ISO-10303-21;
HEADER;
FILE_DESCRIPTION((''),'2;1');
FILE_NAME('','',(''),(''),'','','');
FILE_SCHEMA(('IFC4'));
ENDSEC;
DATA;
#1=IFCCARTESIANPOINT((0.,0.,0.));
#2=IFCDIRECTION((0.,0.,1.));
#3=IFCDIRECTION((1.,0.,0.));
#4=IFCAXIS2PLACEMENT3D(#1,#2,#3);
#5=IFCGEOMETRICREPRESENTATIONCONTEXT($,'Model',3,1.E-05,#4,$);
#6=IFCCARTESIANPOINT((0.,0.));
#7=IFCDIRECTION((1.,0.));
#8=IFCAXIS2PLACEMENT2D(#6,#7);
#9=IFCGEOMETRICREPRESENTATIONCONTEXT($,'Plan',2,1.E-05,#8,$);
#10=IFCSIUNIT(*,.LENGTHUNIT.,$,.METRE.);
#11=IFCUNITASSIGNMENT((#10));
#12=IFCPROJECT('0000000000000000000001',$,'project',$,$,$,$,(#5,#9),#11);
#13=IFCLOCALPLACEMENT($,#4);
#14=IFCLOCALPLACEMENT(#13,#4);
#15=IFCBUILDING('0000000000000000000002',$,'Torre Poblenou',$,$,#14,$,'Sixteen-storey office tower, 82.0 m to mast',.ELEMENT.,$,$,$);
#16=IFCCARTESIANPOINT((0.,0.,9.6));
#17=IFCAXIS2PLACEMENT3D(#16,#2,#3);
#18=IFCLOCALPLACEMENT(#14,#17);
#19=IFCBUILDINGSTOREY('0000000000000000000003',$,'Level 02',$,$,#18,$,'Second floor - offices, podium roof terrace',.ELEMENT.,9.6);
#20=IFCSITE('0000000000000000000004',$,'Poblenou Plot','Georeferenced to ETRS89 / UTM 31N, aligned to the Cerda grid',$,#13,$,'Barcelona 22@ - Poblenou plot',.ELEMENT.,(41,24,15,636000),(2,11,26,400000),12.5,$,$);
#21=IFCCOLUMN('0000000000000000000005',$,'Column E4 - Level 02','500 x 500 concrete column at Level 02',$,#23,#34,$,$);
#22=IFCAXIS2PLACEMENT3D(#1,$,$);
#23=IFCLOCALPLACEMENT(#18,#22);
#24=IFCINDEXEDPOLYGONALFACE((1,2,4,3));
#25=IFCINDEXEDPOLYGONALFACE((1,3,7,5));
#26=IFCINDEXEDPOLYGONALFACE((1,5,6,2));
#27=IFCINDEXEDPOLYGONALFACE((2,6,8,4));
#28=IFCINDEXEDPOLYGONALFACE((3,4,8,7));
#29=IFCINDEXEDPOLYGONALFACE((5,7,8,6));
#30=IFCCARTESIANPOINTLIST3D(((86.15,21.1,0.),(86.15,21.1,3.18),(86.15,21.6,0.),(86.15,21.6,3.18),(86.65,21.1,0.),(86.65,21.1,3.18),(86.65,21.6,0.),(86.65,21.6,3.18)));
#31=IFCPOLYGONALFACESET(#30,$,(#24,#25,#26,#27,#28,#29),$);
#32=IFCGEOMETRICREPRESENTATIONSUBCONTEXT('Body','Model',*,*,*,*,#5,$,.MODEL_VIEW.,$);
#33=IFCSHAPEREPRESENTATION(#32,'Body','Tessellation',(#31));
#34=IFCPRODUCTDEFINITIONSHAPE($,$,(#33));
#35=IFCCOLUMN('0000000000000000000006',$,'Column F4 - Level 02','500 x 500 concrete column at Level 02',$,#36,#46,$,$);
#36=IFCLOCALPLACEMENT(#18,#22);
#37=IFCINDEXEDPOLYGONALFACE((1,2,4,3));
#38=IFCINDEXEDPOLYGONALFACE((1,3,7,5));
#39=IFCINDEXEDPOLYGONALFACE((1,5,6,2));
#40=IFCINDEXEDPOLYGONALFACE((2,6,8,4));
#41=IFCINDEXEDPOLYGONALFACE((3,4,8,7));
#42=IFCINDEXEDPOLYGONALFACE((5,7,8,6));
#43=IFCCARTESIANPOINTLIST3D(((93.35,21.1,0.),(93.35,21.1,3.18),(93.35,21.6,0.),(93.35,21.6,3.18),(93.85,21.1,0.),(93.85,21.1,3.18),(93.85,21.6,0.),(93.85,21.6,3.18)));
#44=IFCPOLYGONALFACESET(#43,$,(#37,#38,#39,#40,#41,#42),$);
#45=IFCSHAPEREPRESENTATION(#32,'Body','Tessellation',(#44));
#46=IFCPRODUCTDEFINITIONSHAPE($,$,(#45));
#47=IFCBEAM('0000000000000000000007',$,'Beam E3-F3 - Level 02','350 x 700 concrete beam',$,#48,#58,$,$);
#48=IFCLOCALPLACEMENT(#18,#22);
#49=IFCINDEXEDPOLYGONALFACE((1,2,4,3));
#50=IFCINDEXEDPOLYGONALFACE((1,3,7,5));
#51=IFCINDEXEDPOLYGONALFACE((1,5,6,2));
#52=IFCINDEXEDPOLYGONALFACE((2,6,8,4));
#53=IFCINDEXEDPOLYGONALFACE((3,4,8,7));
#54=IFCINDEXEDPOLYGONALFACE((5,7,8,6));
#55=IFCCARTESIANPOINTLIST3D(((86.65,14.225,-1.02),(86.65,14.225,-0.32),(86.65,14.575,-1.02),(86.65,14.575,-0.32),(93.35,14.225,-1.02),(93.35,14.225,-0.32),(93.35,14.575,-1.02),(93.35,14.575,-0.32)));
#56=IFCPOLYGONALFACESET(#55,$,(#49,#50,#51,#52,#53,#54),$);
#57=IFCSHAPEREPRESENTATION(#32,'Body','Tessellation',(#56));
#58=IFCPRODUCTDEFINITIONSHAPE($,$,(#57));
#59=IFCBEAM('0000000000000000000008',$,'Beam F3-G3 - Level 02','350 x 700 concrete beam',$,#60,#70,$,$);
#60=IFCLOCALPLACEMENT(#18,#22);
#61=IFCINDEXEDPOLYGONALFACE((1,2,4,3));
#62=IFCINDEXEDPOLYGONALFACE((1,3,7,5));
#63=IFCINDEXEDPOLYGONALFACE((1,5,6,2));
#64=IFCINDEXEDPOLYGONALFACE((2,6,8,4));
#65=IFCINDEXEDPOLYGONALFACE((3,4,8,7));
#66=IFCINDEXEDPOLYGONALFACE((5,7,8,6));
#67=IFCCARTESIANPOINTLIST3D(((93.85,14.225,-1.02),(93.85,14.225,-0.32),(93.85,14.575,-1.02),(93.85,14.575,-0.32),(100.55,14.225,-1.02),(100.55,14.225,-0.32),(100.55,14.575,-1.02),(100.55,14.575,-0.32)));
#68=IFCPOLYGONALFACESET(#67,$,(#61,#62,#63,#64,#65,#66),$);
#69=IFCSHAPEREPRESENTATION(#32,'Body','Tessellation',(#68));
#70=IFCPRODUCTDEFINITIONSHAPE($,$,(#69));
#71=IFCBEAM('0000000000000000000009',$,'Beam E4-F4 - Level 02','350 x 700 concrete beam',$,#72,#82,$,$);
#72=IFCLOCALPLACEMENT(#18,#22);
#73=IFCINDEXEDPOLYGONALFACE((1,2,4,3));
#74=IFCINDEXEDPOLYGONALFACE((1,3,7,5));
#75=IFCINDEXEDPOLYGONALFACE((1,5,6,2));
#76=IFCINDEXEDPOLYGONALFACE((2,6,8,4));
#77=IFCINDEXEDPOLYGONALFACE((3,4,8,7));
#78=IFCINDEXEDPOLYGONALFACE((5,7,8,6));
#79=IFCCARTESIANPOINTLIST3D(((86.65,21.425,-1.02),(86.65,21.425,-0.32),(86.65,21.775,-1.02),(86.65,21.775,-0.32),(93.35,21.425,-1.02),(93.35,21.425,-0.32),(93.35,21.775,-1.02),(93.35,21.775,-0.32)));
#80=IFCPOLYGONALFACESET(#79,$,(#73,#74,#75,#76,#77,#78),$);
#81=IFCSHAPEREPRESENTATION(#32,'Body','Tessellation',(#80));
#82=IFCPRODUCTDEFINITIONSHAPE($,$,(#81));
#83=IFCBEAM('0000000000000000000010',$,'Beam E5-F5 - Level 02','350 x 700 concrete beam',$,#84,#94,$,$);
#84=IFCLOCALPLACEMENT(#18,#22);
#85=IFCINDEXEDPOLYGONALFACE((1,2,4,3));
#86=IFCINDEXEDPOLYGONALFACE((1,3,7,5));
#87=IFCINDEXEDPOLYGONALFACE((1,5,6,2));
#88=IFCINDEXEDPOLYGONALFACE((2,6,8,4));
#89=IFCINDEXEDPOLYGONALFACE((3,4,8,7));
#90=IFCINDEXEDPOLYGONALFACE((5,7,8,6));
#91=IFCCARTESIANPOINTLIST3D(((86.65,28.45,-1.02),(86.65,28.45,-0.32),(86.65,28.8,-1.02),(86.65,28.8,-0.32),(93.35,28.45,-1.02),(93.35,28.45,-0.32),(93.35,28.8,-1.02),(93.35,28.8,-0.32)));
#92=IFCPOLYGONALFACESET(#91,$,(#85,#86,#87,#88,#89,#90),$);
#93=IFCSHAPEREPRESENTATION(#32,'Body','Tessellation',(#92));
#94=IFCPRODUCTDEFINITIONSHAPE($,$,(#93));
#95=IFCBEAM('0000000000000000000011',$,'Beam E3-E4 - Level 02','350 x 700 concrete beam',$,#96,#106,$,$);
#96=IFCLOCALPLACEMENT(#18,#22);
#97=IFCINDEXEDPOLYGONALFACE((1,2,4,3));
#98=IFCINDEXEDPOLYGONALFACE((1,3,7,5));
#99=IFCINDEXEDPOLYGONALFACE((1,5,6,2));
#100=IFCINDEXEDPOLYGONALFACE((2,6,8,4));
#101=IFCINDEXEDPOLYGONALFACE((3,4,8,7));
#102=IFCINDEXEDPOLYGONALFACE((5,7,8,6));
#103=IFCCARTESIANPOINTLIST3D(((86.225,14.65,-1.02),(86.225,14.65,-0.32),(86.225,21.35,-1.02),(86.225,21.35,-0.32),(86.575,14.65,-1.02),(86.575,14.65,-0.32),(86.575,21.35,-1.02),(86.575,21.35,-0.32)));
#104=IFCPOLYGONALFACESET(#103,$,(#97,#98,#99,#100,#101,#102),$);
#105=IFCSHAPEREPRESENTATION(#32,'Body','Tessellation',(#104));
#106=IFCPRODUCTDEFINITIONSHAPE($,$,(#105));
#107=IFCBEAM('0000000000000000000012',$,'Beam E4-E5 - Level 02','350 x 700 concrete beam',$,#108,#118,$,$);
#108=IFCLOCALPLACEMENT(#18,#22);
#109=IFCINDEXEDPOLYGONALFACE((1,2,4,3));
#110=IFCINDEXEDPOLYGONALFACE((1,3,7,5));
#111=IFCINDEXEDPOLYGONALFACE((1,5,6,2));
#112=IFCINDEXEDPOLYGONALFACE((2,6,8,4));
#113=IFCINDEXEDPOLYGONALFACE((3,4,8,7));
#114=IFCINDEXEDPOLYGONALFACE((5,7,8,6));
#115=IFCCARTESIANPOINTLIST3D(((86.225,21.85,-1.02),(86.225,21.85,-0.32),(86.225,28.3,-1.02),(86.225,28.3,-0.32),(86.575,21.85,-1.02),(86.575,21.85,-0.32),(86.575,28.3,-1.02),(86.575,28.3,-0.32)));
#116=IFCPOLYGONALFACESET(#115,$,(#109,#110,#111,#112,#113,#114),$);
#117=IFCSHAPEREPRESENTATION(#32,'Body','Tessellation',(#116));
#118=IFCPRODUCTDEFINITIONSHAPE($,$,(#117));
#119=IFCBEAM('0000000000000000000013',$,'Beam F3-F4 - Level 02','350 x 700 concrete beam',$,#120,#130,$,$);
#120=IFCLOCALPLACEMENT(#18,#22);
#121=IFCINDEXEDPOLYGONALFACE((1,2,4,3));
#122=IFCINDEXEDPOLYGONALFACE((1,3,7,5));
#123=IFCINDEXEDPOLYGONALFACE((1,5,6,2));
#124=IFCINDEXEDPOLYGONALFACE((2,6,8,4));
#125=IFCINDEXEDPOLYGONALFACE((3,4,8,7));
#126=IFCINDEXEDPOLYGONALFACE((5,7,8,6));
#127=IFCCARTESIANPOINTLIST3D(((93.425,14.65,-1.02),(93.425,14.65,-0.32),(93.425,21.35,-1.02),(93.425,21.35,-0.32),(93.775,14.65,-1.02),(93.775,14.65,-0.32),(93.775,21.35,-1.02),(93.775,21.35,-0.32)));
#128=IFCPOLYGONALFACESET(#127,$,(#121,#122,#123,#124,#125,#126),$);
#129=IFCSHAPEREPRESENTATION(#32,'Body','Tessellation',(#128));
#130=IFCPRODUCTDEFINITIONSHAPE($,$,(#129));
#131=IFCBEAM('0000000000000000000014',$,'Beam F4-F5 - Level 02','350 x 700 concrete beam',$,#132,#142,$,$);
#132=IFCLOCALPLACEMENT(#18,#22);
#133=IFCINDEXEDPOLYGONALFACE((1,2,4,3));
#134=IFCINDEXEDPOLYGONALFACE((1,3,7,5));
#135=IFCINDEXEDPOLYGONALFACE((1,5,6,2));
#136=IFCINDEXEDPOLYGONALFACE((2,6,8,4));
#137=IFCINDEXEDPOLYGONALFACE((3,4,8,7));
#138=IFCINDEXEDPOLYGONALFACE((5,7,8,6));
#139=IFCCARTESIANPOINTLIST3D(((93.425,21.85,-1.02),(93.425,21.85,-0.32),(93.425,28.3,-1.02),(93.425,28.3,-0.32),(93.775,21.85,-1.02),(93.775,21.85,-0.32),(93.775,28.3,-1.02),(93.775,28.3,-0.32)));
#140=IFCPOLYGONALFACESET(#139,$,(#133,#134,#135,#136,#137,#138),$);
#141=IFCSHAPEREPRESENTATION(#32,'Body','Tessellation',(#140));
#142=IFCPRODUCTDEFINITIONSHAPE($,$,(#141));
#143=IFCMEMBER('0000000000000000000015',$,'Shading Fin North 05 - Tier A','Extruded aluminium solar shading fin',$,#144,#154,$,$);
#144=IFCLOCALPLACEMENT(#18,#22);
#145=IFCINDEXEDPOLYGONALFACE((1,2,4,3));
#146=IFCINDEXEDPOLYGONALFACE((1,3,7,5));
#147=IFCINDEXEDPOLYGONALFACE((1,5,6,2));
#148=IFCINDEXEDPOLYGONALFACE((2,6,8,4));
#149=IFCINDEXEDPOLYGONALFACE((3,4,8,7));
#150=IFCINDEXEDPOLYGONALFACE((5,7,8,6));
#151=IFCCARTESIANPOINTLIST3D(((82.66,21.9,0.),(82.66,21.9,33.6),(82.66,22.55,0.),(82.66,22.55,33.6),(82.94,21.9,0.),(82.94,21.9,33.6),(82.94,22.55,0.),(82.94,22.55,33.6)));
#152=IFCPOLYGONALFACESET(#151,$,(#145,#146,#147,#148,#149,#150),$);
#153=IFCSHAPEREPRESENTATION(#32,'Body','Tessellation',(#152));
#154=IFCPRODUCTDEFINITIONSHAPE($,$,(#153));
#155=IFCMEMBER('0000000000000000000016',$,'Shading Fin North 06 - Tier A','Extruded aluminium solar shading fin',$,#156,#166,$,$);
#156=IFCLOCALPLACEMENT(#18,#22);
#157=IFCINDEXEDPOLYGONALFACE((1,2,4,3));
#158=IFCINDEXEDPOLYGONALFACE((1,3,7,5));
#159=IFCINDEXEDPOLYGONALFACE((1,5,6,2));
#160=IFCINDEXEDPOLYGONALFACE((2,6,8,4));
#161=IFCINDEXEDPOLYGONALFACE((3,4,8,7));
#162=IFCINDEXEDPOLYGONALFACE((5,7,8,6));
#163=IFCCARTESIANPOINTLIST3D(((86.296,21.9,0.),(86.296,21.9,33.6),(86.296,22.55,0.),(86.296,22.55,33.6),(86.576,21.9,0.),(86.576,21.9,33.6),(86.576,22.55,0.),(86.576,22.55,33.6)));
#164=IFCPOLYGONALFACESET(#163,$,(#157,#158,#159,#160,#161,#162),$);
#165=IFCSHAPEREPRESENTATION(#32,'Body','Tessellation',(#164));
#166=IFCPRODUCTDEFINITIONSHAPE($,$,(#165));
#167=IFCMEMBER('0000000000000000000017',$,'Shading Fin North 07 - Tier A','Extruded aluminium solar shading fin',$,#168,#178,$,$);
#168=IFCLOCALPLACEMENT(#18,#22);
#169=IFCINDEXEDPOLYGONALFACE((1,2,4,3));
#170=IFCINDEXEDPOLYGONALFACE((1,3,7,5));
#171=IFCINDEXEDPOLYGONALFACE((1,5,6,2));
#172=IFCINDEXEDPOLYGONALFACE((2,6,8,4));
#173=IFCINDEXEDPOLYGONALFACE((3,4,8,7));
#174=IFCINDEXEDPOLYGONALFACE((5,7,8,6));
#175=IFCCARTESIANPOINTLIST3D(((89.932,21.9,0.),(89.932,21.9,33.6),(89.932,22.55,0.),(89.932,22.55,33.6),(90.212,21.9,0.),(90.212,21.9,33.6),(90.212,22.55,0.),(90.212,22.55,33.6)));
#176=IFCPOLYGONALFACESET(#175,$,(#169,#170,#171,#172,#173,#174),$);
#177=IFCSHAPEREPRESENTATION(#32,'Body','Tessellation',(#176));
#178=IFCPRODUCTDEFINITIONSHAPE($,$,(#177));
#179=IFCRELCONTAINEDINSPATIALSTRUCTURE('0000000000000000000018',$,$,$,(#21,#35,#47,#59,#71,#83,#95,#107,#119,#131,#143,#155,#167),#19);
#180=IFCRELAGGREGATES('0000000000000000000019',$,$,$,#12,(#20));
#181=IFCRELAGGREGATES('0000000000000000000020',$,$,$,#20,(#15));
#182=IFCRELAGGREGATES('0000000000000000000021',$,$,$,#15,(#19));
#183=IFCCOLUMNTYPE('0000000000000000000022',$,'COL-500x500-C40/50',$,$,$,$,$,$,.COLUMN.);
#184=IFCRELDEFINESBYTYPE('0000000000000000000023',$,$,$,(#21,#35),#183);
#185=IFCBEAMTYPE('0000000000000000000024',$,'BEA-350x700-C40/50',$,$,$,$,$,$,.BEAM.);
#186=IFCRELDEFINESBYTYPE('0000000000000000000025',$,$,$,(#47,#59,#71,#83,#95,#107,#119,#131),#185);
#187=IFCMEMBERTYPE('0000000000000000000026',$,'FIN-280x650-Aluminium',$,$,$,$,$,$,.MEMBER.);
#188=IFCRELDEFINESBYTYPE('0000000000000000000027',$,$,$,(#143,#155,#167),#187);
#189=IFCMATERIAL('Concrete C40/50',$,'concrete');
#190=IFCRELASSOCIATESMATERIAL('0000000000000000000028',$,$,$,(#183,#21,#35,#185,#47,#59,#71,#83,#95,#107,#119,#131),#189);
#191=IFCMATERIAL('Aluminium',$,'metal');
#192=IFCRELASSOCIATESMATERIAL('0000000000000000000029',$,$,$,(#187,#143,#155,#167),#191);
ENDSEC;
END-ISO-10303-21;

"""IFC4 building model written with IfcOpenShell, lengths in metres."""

from ifc_helpers import new_model, si_unit, frame, origin_with_axes, origin_2d_with_axis, place, context, subcontext, project, spatial, line, indexed_curve, rectangle, outline, extrude, material, material_profile, profile_set, profile_usage, type_object, element, save


model = new_model("IFC4")

# Units and contexts
model_context = context("Model", 3, precision=1e-05, world=origin_with_axes())
plan_context = context("Plan", 2, precision=1e-05, world=origin_2d_with_axis())
body_context = subcontext(model_context, "Body", "Model", "MODEL_VIEW")
ifc_project = project(units=[si_unit("LENGTHUNIT", "METRE")], contexts=[model_context, plan_context])

# Site, building, storey
site_placement = place(None, origin_with_axes())
site = spatial("IfcSite", under=ifc_project, at=site_placement, Name="Poblenou Plot", Description="Georeferenced to ETRS89 / UTM 31N, aligned to the Cerda grid", LongName="Barcelona 22@ - Poblenou plot", CompositionType="ELEMENT", RefLatitude=(41, 24, 15, 636000), RefLongitude=(2, 11, 26, 400000), RefElevation=12.5)
building_placement = place(site_placement, origin_with_axes())
building = spatial("IfcBuilding", under=site, at=building_placement, Name="Torre Poblenou", LongName="Sixteen-storey office tower, 82.0 m to mast", CompositionType="ELEMENT")
storey_placement = place(building_placement, frame((0.0, 0.0, 9.6), z_axis=(0.0, 0.0, 1.0), x_axis=(1.0, 0.0, 0.0)))
storey = spatial("IfcBuildingStorey", under=building, at=storey_placement, Name="Level 02", LongName="Second floor - offices, podium roof terrace", CompositionType="ELEMENT", Elevation=9.6)

# Columns
ifc_material_1 = material(Name="Concrete C40/50", Category="concrete")
ifc_material_profile_1 = material_profile(ifc_material_1, rectangle(XDim=0.5, YDim=0.5))
ifc_profile_set_1 = profile_set([ifc_material_profile_1], Name="COL-500x500-C40/50")
ifc_profile_usage_1 = profile_usage(ifc_profile_set_1)
column_type = type_object("IfcColumnType", Name="COL-500x500-C40/50", PredefinedType="COLUMN", material=ifc_profile_set_1)
column_1_placement = place(storey_placement, frame((86.15, 21.1, 0.0), z_axis=(0.0, 0.0, 1.0), x_axis=(1.0, 0.0, 0.0)))
element("IfcColumn", 1, at=column_1_placement, inside=storey, type_object=column_type, material=ifc_profile_usage_1, Name="Column E4 - Level 02", Description="500 x 500 concrete column at Level 02", context=body_context, shape_type="SweptSolid", body=[
    extrude(outline(indexed_curve([(0.0, 0.0), (0.5, 0.0), (0.5, 0.5), (0.0, 0.5)], segments=[line(1, 2, 3, 4, 1)])), origin_with_axes(), (0.0, 0.0, 1.0), 3.18),
])
ifc_profile_usage_2 = profile_usage(ifc_profile_set_1)
column_2_placement = place(storey_placement, frame((93.35, 21.1, 0.0), z_axis=(0.0, 0.0, 1.0), x_axis=(1.0, 0.0, 0.0)))
element("IfcColumn", 2, at=column_2_placement, inside=storey, type_object=column_type, material=ifc_profile_usage_2, Name="Column F4 - Level 02", Description="500 x 500 concrete column at Level 02", context=body_context, shape_type="SweptSolid", body=[
    extrude(outline(indexed_curve([(0.0, 0.0), (0.5, 0.0), (0.5, 0.5), (0.0, 0.5)], segments=[line(1, 2, 3, 4, 1)])), origin_with_axes(), (0.0, 0.0, 1.0), 3.18),
])

# Beams
ifc_material_profile_2 = material_profile(ifc_material_1, rectangle(XDim=0.35, YDim=0.7))
ifc_profile_set_2 = profile_set([ifc_material_profile_2], Name="BEA-350x700-C40/50")
ifc_profile_usage_3 = profile_usage(ifc_profile_set_2)
beam_type = type_object("IfcBeamType", Name="BEA-350x700-C40/50", PredefinedType="BEAM", material=ifc_profile_set_2)
beam_1_placement = place(storey_placement, frame((86.65, 14.225, -1.02), z_axis=(0.0, 0.0, 1.0), x_axis=(1.0, 0.0, 0.0)))
element("IfcBeam", 3, at=beam_1_placement, inside=storey, type_object=beam_type, material=ifc_profile_usage_3, Name="Beam E3-F3 - Level 02", Description="350 x 700 concrete beam", context=body_context, shape_type="SweptSolid", body=[
    extrude(outline(indexed_curve([(0.0, 0.0), (6.7, 0.0), (6.7, 0.35), (0.0, 0.35)], segments=[line(1, 2, 3, 4, 1)])), origin_with_axes(), (0.0, 0.0, 1.0), 0.7),
])
ifc_profile_usage_4 = profile_usage(ifc_profile_set_2)
beam_2_placement = place(storey_placement, frame((93.85, 14.225, -1.02), z_axis=(0.0, 0.0, 1.0), x_axis=(1.0, 0.0, 0.0)))
element("IfcBeam", 4, at=beam_2_placement, inside=storey, type_object=beam_type, material=ifc_profile_usage_4, Name="Beam F3-G3 - Level 02", Description="350 x 700 concrete beam", context=body_context, shape_type="SweptSolid", body=[
    extrude(outline(indexed_curve([(0.0, 0.0), (6.7, 0.0), (6.7, 0.35), (0.0, 0.35)], segments=[line(1, 2, 3, 4, 1)])), origin_with_axes(), (0.0, 0.0, 1.0), 0.7),
])
ifc_profile_usage_5 = profile_usage(ifc_profile_set_2)
beam_3_placement = place(storey_placement, frame((86.65, 21.425, -1.02), z_axis=(0.0, 0.0, 1.0), x_axis=(1.0, 0.0, 0.0)))
element("IfcBeam", 5, at=beam_3_placement, inside=storey, type_object=beam_type, material=ifc_profile_usage_5, Name="Beam E4-F4 - Level 02", Description="350 x 700 concrete beam", context=body_context, shape_type="SweptSolid", body=[
    extrude(outline(indexed_curve([(0.0, 0.0), (6.7, 0.0), (6.7, 0.35), (0.0, 0.35)], segments=[line(1, 2, 3, 4, 1)])), origin_with_axes(), (0.0, 0.0, 1.0), 0.7),
])
ifc_profile_usage_6 = profile_usage(ifc_profile_set_2)
beam_4_placement = place(storey_placement, frame((86.65, 28.45, -1.02), z_axis=(0.0, 0.0, 1.0), x_axis=(1.0, 0.0, 0.0)))
element("IfcBeam", 6, at=beam_4_placement, inside=storey, type_object=beam_type, material=ifc_profile_usage_6, Name="Beam E5-F5 - Level 02", Description="350 x 700 concrete beam", context=body_context, shape_type="SweptSolid", body=[
    extrude(outline(indexed_curve([(0.0, 0.0), (6.7, 0.0), (6.7, 0.35), (0.0, 0.35)], segments=[line(1, 2, 3, 4, 1)])), origin_with_axes(), (0.0, 0.0, 1.0), 0.7),
])
ifc_profile_usage_7 = profile_usage(ifc_profile_set_2)
beam_5_placement = place(storey_placement, frame((86.575, 14.65, -1.02), z_axis=(0.0, 0.0, 1.0), x_axis=(0.0, 1.0, 0.0)))
element("IfcBeam", 7, at=beam_5_placement, inside=storey, type_object=beam_type, material=ifc_profile_usage_7, Name="Beam E3-E4 - Level 02", Description="350 x 700 concrete beam", context=body_context, shape_type="SweptSolid", body=[
    extrude(outline(indexed_curve([(0.0, 0.0), (6.7, 0.0), (6.7, 0.35), (0.0, 0.35)], segments=[line(1, 2, 3, 4, 1)])), origin_with_axes(), (0.0, 0.0, 1.0), 0.7),
])
ifc_profile_usage_8 = profile_usage(ifc_profile_set_2)
beam_6_placement = place(storey_placement, frame((86.575, 21.85, -1.02), z_axis=(0.0, 0.0, 1.0), x_axis=(0.0, 1.0, 0.0)))
element("IfcBeam", 8, at=beam_6_placement, inside=storey, type_object=beam_type, material=ifc_profile_usage_8, Name="Beam E4-E5 - Level 02", Description="350 x 700 concrete beam", context=body_context, shape_type="SweptSolid", body=[
    extrude(outline(indexed_curve([(0.0, 0.0), (6.45, 0.0), (6.45, 0.35), (0.0, 0.35)], segments=[line(1, 2, 3, 4, 1)])), origin_with_axes(), (0.0, 0.0, 1.0), 0.7),
])
ifc_profile_usage_9 = profile_usage(ifc_profile_set_2)
beam_7_placement = place(storey_placement, frame((93.775, 14.65, -1.02), z_axis=(0.0, 0.0, 1.0), x_axis=(0.0, 1.0, 0.0)))
element("IfcBeam", 9, at=beam_7_placement, inside=storey, type_object=beam_type, material=ifc_profile_usage_9, Name="Beam F3-F4 - Level 02", Description="350 x 700 concrete beam", context=body_context, shape_type="SweptSolid", body=[
    extrude(outline(indexed_curve([(0.0, 0.0), (6.7, 0.0), (6.7, 0.35), (0.0, 0.35)], segments=[line(1, 2, 3, 4, 1)])), origin_with_axes(), (0.0, 0.0, 1.0), 0.7),
])
ifc_profile_usage_10 = profile_usage(ifc_profile_set_2)
beam_8_placement = place(storey_placement, frame((93.775, 21.85, -1.02), z_axis=(0.0, 0.0, 1.0), x_axis=(0.0, 1.0, 0.0)))
element("IfcBeam", 10, at=beam_8_placement, inside=storey, type_object=beam_type, material=ifc_profile_usage_10, Name="Beam F4-F5 - Level 02", Description="350 x 700 concrete beam", context=body_context, shape_type="SweptSolid", body=[
    extrude(outline(indexed_curve([(0.0, 0.0), (6.45, 0.0), (6.45, 0.35), (0.0, 0.35)], segments=[line(1, 2, 3, 4, 1)])), origin_with_axes(), (0.0, 0.0, 1.0), 0.7),
])

# Members
ifc_material_2 = material(Name="Aluminium", Category="metal")
ifc_material_profile_3 = material_profile(ifc_material_2, rectangle(XDim=0.28, YDim=0.65))
ifc_profile_set_3 = profile_set([ifc_material_profile_3], Name="FIN-280x650-Aluminium")
ifc_profile_usage_11 = profile_usage(ifc_profile_set_3)
member_type = type_object("IfcMemberType", Name="FIN-280x650-Aluminium", PredefinedType="MEMBER", material=ifc_profile_set_3)
member_1_placement = place(storey_placement, frame((82.66, 21.9, 0.0), z_axis=(0.0, 0.0, 1.0), x_axis=(1.0, 0.0, 0.0)))
element("IfcMember", 11, at=member_1_placement, inside=storey, type_object=member_type, material=ifc_profile_usage_11, Name="Shading Fin North 05 - Tier A", Description="Extruded aluminium solar shading fin", context=body_context, shape_type="SweptSolid", body=[
    extrude(outline(indexed_curve([(0.0, 0.0), (0.28, 0.0), (0.28, 0.65), (0.0, 0.65)], segments=[line(1, 2, 3, 4, 1)])), origin_with_axes(), (0.0, 0.0, 1.0), 33.6),
])
ifc_profile_usage_12 = profile_usage(ifc_profile_set_3)
member_2_placement = place(storey_placement, frame((86.296, 21.9, 0.0), z_axis=(0.0, 0.0, 1.0), x_axis=(1.0, 0.0, 0.0)))
element("IfcMember", 12, at=member_2_placement, inside=storey, type_object=member_type, material=ifc_profile_usage_12, Name="Shading Fin North 06 - Tier A", Description="Extruded aluminium solar shading fin", context=body_context, shape_type="SweptSolid", body=[
    extrude(outline(indexed_curve([(0.0, 0.0), (0.28, 0.0), (0.28, 0.65), (0.0, 0.65)], segments=[line(1, 2, 3, 4, 1)])), origin_with_axes(), (0.0, 0.0, 1.0), 33.6),
])
ifc_profile_usage_13 = profile_usage(ifc_profile_set_3)
member_3_placement = place(storey_placement, frame((89.932, 21.9, 0.0), z_axis=(0.0, 0.0, 1.0), x_axis=(1.0, 0.0, 0.0)))
element("IfcMember", 13, at=member_3_placement, inside=storey, type_object=member_type, material=ifc_profile_usage_13, Name="Shading Fin North 07 - Tier A", Description="Extruded aluminium solar shading fin", context=body_context, shape_type="SweptSolid", body=[
    extrude(outline(indexed_curve([(0.0, 0.0), (0.28, 0.0), (0.28, 0.65), (0.0, 0.65)], segments=[line(1, 2, 3, 4, 1)])), origin_with_axes(), (0.0, 0.0, 1.0), 33.6),
])

save(model, "model.ifc")
